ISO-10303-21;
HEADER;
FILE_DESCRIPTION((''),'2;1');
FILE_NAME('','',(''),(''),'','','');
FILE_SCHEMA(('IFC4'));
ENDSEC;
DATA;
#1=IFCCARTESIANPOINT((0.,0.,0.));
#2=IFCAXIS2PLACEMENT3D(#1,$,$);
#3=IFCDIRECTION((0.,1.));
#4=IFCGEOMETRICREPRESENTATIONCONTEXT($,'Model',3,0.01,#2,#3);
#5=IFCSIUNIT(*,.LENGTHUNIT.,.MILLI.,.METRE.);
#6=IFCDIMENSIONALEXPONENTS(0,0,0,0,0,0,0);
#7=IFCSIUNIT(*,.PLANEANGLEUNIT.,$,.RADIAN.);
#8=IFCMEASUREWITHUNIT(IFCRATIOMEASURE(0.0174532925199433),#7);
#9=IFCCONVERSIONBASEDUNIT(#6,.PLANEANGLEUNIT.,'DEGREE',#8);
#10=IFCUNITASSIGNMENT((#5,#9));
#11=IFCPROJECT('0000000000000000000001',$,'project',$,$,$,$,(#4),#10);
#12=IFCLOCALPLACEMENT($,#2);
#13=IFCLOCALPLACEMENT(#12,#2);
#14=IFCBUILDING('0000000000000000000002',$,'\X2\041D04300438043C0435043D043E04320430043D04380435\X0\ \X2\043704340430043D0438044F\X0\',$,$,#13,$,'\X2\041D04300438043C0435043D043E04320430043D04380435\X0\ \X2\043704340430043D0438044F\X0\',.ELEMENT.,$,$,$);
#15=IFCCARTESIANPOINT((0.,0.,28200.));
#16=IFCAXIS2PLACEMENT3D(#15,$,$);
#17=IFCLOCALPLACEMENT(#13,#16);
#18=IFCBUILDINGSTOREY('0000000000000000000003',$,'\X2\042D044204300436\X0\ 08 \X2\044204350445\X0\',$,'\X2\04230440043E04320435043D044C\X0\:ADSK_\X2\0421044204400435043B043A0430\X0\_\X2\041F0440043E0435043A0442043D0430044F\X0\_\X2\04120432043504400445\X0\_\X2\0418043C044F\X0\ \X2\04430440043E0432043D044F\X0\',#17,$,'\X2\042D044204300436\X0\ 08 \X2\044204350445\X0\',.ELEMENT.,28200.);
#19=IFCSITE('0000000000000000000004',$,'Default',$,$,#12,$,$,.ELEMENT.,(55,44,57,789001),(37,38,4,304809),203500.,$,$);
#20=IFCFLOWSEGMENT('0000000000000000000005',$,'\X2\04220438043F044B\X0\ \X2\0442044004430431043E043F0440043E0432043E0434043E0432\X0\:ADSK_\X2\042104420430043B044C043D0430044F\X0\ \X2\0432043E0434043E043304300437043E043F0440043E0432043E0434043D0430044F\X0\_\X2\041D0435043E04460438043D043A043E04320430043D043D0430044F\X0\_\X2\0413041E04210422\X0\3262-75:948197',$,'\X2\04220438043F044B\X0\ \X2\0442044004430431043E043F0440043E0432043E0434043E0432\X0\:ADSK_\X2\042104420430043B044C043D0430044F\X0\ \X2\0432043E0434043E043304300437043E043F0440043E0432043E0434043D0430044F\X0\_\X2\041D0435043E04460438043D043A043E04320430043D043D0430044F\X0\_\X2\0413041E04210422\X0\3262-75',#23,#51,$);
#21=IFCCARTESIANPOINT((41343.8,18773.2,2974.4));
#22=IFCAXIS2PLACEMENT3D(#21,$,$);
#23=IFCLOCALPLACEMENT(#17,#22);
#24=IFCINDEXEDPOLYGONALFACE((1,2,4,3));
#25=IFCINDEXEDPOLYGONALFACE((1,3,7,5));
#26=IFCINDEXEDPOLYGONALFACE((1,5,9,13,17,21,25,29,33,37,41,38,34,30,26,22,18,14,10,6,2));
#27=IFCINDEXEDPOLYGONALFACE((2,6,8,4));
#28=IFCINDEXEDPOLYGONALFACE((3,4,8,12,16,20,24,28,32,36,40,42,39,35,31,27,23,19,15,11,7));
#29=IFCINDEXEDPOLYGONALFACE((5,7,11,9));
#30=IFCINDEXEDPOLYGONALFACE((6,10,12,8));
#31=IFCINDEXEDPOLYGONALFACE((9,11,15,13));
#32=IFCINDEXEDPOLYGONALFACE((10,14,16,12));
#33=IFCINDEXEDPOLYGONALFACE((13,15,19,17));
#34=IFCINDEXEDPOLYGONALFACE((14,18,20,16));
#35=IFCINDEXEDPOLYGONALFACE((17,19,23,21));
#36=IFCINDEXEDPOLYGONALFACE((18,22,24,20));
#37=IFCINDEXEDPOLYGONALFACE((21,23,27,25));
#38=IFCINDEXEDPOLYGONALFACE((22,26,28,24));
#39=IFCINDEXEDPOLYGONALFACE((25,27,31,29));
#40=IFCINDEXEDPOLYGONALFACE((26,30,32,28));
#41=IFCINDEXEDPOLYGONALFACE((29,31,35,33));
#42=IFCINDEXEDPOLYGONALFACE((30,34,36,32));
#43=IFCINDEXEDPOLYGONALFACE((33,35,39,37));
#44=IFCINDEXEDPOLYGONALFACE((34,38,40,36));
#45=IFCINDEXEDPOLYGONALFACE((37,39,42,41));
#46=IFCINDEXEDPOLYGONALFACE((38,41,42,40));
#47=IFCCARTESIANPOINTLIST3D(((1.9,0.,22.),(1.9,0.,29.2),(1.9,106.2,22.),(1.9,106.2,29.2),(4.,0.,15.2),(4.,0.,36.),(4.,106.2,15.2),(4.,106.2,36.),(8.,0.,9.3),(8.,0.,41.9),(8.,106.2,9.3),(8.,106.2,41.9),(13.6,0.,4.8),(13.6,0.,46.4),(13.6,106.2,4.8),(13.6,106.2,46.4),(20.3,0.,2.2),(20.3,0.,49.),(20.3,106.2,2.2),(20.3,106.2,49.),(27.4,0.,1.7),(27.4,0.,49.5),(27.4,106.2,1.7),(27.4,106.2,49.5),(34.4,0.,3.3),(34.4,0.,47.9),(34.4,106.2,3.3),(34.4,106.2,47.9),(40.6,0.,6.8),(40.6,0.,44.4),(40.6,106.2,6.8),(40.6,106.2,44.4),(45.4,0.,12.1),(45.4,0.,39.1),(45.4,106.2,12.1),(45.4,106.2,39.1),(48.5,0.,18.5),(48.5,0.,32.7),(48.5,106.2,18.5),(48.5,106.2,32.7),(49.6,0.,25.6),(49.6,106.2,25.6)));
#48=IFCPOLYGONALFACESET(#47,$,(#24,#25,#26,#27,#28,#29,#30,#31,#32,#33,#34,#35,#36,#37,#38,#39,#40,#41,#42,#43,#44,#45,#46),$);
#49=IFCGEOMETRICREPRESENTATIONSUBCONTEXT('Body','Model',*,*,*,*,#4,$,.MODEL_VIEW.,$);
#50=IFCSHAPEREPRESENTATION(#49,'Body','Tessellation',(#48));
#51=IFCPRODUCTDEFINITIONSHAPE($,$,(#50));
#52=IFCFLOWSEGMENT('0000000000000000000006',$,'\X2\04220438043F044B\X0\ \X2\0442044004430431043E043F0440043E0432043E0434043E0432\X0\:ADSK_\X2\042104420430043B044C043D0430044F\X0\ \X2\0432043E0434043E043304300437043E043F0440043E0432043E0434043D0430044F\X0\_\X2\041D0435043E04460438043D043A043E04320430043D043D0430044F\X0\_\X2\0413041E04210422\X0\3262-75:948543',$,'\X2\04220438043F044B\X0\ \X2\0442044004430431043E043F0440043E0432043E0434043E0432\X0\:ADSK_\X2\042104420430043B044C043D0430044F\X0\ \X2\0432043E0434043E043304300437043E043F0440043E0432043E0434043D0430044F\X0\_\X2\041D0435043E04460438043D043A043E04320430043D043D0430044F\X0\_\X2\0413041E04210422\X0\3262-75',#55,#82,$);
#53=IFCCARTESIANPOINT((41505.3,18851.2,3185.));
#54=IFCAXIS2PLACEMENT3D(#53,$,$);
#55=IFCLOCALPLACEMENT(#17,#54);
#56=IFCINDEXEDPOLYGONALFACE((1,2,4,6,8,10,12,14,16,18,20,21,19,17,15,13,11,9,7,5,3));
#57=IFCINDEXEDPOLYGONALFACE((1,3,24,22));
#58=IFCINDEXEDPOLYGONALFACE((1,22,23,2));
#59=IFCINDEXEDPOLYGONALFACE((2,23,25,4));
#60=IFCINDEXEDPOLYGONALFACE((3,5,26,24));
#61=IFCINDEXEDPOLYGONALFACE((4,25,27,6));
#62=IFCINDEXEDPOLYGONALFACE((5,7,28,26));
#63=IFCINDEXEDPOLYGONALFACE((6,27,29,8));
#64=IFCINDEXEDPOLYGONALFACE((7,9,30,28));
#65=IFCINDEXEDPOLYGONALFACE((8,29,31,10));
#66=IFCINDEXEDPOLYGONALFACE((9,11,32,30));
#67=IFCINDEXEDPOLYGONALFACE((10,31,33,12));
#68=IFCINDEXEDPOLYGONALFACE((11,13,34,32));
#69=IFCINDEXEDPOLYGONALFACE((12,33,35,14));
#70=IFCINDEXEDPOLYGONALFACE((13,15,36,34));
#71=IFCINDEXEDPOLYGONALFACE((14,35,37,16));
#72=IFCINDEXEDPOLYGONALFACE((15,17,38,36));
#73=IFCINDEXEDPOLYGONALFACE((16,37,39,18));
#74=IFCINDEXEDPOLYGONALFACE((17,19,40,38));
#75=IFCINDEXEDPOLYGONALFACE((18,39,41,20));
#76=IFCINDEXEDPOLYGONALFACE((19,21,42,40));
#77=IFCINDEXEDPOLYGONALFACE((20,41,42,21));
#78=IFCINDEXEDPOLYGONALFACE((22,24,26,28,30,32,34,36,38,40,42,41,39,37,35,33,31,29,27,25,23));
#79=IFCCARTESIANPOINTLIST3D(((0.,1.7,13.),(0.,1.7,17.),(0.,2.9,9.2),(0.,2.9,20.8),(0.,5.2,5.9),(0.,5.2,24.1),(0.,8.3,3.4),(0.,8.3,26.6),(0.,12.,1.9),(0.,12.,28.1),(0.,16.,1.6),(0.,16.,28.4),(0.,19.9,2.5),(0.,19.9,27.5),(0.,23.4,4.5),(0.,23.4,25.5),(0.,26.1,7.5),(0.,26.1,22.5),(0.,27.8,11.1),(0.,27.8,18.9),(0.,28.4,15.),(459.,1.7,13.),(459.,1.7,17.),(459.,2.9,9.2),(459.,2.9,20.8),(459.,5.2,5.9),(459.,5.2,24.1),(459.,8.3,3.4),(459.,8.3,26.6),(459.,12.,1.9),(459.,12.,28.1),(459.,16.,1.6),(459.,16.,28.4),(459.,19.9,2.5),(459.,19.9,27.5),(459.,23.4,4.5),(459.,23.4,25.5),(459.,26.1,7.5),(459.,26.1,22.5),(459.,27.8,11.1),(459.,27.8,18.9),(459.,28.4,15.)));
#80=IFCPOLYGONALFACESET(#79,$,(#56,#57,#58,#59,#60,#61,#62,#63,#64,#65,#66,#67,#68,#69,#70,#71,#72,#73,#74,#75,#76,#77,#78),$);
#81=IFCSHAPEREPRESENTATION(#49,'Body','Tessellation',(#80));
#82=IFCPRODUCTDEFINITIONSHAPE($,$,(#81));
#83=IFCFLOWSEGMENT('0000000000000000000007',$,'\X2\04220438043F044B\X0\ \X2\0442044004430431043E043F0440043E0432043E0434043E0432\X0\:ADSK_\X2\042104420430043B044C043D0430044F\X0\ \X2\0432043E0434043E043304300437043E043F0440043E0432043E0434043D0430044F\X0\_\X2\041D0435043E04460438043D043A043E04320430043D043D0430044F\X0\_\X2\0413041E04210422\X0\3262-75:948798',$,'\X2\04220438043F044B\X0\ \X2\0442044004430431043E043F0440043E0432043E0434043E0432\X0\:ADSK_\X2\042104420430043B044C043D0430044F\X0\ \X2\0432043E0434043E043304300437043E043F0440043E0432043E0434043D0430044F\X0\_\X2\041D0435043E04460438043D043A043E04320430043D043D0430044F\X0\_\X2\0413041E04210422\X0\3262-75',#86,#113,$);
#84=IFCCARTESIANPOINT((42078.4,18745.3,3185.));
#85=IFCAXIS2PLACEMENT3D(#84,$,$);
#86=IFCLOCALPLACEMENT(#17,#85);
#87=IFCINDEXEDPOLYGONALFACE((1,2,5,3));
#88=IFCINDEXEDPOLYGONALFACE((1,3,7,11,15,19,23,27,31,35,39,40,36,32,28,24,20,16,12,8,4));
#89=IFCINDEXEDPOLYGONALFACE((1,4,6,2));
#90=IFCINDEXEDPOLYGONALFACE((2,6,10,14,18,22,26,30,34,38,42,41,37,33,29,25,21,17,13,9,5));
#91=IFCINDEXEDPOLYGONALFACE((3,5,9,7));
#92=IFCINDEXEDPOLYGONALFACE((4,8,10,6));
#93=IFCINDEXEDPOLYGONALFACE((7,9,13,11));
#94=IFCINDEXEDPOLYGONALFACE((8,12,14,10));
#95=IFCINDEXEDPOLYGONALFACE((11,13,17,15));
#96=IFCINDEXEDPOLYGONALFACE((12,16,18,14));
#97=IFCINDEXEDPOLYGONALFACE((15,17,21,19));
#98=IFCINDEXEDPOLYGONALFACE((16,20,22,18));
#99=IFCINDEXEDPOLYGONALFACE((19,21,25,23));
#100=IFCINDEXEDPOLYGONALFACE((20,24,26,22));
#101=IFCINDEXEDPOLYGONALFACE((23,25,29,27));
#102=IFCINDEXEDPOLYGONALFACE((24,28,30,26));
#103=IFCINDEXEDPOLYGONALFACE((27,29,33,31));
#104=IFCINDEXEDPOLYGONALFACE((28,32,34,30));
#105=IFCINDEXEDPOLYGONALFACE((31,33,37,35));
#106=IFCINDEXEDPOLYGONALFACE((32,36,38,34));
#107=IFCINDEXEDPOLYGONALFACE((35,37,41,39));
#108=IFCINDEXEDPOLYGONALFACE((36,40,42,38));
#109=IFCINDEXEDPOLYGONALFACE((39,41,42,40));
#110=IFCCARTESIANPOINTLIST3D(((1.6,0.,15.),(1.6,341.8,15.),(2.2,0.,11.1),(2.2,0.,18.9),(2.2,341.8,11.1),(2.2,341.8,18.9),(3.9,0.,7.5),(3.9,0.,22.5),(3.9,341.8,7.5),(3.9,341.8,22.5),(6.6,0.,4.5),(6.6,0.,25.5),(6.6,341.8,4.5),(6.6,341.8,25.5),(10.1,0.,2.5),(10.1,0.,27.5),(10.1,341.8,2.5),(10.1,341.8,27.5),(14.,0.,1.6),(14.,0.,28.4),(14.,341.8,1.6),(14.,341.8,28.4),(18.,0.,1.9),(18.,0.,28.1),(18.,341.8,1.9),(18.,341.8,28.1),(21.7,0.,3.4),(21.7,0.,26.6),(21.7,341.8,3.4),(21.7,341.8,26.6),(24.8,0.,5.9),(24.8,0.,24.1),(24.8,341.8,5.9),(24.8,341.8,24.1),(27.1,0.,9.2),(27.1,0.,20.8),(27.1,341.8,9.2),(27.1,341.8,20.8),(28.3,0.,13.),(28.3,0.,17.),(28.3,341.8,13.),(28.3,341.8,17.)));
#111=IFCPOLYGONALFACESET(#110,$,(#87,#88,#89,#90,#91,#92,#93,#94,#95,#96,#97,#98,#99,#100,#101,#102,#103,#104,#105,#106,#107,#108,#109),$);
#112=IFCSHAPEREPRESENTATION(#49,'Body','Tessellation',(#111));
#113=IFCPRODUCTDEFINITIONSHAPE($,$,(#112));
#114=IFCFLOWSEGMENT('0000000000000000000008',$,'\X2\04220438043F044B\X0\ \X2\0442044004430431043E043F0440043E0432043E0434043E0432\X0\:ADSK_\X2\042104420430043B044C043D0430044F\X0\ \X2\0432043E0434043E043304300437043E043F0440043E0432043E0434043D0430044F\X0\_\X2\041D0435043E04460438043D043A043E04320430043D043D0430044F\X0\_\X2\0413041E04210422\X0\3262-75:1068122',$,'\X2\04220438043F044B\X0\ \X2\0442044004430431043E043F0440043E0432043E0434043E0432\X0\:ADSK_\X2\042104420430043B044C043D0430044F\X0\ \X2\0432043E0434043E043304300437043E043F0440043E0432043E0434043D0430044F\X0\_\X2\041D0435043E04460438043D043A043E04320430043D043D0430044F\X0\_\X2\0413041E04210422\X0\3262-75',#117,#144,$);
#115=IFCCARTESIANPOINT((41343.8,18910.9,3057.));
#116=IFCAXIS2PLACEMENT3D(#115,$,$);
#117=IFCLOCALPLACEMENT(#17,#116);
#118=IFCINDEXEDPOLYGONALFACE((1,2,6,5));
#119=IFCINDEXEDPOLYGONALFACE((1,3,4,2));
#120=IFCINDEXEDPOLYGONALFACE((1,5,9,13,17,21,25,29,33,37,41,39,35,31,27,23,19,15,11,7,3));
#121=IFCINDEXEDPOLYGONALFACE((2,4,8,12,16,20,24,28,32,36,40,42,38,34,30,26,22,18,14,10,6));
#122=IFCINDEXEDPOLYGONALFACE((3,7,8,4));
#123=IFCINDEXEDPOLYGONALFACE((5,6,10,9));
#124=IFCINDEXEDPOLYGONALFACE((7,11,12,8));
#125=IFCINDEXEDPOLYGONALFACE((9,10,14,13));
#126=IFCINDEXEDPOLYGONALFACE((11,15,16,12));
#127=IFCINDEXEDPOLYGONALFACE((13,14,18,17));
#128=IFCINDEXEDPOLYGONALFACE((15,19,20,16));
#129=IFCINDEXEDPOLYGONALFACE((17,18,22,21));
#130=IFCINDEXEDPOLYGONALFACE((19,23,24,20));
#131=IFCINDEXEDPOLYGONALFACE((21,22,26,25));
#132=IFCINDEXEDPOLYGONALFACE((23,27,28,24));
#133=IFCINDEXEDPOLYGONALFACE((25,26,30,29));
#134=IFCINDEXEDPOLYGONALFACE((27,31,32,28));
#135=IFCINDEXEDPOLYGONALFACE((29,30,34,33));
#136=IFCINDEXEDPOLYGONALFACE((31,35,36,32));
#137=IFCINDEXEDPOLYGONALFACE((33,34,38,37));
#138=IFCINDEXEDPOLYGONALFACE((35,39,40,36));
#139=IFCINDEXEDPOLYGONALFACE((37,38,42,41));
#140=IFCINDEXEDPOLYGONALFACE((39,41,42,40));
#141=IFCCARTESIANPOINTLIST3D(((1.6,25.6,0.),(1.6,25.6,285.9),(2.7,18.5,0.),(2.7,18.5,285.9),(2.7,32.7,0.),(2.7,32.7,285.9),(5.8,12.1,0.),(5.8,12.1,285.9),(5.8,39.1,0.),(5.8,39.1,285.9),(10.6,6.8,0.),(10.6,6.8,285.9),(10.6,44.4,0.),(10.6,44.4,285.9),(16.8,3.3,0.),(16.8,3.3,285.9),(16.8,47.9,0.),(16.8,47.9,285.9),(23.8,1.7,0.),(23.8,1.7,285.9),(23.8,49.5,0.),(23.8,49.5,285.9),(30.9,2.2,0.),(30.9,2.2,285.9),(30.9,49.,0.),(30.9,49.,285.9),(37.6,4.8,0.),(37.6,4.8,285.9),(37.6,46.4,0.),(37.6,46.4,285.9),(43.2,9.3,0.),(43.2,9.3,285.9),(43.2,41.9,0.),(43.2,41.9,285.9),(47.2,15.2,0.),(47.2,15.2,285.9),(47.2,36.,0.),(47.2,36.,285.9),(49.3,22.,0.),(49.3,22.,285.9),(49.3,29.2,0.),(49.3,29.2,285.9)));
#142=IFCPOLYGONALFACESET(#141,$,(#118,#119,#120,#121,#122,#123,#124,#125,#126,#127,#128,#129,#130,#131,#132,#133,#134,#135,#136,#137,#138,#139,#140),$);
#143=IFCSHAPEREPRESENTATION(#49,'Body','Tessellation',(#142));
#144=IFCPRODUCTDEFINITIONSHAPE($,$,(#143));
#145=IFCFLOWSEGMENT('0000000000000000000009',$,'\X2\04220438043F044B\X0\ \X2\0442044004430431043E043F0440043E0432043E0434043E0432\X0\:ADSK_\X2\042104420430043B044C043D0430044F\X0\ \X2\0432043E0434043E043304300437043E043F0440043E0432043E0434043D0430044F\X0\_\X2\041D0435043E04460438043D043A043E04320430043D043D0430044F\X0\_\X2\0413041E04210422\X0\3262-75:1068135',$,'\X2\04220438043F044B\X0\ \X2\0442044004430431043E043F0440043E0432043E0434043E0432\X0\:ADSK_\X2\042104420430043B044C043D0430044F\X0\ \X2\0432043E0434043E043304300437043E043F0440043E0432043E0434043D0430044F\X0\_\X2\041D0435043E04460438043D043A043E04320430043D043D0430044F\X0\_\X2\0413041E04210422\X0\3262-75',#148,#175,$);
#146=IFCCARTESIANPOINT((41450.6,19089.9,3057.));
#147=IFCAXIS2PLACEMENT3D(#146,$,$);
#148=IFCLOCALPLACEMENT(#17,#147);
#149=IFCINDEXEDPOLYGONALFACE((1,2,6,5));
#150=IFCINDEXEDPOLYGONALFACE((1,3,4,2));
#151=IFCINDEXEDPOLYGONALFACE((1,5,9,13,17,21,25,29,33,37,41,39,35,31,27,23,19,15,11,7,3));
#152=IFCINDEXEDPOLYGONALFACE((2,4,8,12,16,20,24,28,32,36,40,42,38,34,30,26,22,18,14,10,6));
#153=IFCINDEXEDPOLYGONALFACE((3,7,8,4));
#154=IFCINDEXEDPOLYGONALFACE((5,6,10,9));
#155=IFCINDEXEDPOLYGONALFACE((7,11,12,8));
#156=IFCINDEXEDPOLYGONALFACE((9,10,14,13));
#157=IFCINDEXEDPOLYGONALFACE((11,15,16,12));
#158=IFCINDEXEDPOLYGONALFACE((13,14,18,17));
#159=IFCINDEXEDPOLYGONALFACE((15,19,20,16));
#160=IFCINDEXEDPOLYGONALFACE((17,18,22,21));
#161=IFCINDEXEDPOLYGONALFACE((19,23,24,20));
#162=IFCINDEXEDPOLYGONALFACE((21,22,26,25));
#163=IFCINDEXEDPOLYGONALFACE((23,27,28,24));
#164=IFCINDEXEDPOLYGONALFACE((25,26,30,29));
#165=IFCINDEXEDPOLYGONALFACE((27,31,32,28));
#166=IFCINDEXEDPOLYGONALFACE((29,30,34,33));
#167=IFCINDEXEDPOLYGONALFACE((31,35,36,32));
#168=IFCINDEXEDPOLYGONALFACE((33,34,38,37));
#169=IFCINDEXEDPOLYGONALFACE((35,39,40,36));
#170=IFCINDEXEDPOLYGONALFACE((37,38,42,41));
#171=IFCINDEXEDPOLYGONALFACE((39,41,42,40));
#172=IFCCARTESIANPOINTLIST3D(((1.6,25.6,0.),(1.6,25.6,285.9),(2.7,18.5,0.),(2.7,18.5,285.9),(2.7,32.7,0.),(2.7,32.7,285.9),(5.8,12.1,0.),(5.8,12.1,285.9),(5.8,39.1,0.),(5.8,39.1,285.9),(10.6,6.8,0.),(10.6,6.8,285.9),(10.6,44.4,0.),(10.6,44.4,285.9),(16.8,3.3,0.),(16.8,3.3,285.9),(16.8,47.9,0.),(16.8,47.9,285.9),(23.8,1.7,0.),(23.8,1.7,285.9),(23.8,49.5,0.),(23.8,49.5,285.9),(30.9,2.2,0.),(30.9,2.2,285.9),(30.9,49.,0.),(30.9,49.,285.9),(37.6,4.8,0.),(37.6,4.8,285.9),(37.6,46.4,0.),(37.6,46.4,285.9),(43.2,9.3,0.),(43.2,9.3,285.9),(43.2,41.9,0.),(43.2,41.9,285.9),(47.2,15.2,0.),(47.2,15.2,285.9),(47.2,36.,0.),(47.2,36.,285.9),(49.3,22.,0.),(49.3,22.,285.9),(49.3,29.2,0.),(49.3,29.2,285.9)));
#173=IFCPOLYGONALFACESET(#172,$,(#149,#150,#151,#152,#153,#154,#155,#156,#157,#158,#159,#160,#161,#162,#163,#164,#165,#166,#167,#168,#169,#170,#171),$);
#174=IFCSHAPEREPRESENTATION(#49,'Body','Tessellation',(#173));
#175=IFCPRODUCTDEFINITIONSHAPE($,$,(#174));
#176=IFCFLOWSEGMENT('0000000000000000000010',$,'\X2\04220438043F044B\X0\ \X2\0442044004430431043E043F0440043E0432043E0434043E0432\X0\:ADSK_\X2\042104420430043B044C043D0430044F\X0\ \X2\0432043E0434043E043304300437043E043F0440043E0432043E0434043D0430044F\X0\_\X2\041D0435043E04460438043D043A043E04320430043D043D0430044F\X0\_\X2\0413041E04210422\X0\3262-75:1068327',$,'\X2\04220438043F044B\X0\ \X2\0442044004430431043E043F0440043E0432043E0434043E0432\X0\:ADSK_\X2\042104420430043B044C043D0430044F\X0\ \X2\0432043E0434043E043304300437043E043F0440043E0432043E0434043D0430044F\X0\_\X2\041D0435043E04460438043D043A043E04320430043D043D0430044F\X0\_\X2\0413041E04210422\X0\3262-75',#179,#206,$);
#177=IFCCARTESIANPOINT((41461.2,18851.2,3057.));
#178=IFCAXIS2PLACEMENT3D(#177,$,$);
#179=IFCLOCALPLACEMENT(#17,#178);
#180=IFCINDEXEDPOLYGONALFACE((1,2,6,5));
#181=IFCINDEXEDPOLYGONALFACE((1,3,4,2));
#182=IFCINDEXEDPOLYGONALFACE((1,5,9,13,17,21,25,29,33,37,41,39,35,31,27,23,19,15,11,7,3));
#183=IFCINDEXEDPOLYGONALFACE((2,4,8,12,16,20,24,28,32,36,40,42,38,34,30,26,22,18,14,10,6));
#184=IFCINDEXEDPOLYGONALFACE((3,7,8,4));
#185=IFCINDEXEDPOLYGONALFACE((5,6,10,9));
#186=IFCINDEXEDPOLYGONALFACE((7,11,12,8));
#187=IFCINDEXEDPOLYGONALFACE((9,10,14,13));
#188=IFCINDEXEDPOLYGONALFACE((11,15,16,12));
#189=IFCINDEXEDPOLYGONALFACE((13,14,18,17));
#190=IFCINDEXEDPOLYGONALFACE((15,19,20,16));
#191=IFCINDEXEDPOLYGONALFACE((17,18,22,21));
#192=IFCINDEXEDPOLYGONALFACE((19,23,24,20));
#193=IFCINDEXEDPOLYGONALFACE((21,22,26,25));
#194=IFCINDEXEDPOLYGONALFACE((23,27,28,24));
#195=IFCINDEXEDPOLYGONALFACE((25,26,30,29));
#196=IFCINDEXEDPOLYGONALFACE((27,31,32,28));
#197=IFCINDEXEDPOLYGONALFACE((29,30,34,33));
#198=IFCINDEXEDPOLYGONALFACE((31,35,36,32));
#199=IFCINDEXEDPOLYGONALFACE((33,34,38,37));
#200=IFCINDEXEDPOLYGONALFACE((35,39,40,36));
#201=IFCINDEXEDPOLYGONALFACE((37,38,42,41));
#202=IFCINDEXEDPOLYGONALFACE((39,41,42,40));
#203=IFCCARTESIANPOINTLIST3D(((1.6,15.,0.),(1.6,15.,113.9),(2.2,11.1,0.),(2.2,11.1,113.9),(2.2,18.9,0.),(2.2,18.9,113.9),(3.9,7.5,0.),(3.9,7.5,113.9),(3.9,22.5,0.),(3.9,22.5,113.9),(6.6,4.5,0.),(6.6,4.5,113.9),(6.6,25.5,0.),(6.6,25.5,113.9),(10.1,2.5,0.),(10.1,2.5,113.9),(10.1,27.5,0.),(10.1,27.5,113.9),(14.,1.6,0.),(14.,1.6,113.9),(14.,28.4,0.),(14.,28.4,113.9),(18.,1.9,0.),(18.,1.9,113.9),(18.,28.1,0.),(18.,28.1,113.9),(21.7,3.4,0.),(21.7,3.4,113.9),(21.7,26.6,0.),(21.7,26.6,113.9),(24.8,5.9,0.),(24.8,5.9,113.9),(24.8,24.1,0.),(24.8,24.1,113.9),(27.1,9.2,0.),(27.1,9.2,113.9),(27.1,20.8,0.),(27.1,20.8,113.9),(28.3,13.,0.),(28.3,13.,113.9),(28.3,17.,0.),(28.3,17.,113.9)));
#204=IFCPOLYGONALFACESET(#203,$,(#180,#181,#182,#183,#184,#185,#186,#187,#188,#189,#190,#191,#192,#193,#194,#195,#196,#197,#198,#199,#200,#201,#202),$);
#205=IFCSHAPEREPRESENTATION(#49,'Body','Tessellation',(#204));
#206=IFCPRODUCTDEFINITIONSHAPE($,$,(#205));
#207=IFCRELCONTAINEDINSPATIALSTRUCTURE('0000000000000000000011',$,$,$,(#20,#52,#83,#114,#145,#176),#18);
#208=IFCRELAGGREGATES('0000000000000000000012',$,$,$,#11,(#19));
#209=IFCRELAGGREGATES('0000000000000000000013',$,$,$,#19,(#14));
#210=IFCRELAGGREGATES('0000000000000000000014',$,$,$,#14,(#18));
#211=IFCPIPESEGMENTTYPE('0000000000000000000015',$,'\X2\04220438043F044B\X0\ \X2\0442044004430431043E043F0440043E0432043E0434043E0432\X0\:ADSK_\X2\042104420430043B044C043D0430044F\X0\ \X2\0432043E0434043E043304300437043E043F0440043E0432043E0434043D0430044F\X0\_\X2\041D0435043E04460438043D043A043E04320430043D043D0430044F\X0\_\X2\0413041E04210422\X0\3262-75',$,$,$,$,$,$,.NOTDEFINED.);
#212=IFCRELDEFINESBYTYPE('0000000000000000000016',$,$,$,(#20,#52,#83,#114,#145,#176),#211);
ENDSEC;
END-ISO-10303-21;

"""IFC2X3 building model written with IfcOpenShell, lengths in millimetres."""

from ifc_helpers import new_model, entity, si_unit, converted_unit, direction, frame, origin, origin_2d_with_axis, place, context, subcontext, project, spatial, circle, extrude, type_object, element, save


model = new_model("IFC2X3")

# Units and contexts
model_context = context("Model", 3, precision=0.01, world=origin(), true_north=direction((0.0, 1.0)))
body_context = subcontext(model_context, "Body", "Model", "MODEL_VIEW")
ifc_project = project(units=[si_unit("LENGTHUNIT", "METRE", prefix="MILLI"), converted_unit("PLANEANGLEUNIT", "DEGREE", entity("IfcRatioMeasure", 0.0174532925199433), si_unit("PLANEANGLEUNIT", "RADIAN"), dimensions=[0, 0, 0, 0, 0, 0, 0])], contexts=[model_context])

# Site, building, storey
site_placement = place(None, origin())
site = spatial("IfcSite", under=ifc_project, at=site_placement, Name="Default", CompositionType="ELEMENT", RefLatitude=(55, 44, 57, 789001), RefLongitude=(37, 38, 4, 304809), RefElevation=203500.0)
building_placement = place(site_placement, origin())
building = spatial("IfcBuilding", under=site, at=building_placement, Name="Наименование здания", LongName="Наименование здания", CompositionType="ELEMENT")
storey_placement = place(building_placement, frame((0.0, 0.0, 28200.0)))
storey = spatial("IfcBuildingStorey", under=building, at=storey_placement, Name="Этаж 08 тех", ObjectType="Уровень:ADSK_Стрелка_Проектная_Вверх_Имя уровня", LongName="Этаж 08 тех", CompositionType="ELEMENT", Elevation=28200.0)

# Flow segments
pipe_segment_type = type_object("IfcPipeSegmentType", Name="Типы трубопроводов:ADSK_Стальная водогазопроводная_Неоцинкованная_ГОСТ3262-75", PredefinedType="NOTDEFINED")
flow_segment_1_placement = place(storey_placement, frame((41343.8, 18773.2, 2974.4)))
element("IfcFlowSegment", 1, at=flow_segment_1_placement, inside=storey, type_object=pipe_segment_type, Name="Типы трубопроводов:ADSK_Стальная водогазопроводная_Неоцинкованная_ГОСТ3262-75:948197", ObjectType="Типы трубопроводов:ADSK_Стальная водогазопроводная_Неоцинкованная_ГОСТ3262-75", context=body_context, shape_type="SweptSolid", body=[
    extrude(circle(Radius=24.0, at=origin_2d_with_axis()), frame((25.6, 0.0, 25.6), z_axis=(0.0, 1.0, 0.0), x_axis=(1.0, 0.0, 0.0)), (0.0, 0.0, 1.0), 106.2),
])
flow_segment_2_placement = place(storey_placement, frame((41505.3, 18851.2, 3185.0)))
element("IfcFlowSegment", 2, at=flow_segment_2_placement, inside=storey, type_object=pipe_segment_type, Name="Типы трубопроводов:ADSK_Стальная водогазопроводная_Неоцинкованная_ГОСТ3262-75:948543", ObjectType="Типы трубопроводов:ADSK_Стальная водогазопроводная_Неоцинкованная_ГОСТ3262-75", context=body_context, shape_type="SweptSolid", body=[
    extrude(circle(Radius=13.4, at=origin_2d_with_axis()), frame((0.0, 15.0, 15.0), z_axis=(1.0, 0.0, 0.0), x_axis=(0.0, 1.0, 0.0)), (0.0, 0.0, 1.0), 459.0),
])
flow_segment_3_placement = place(storey_placement, frame((42078.4, 18745.3, 3185.0)))
element("IfcFlowSegment", 3, at=flow_segment_3_placement, inside=storey, type_object=pipe_segment_type, Name="Типы трубопроводов:ADSK_Стальная водогазопроводная_Неоцинкованная_ГОСТ3262-75:948798", ObjectType="Типы трубопроводов:ADSK_Стальная водогазопроводная_Неоцинкованная_ГОСТ3262-75", context=body_context, shape_type="SweptSolid", body=[
    extrude(circle(Radius=13.4, at=origin_2d_with_axis()), frame((15.0, 0.0, 15.0), z_axis=(0.0, 1.0, 0.0), x_axis=(-1.0, 0.0, 0.0)), (0.0, 0.0, 1.0), 341.8),
])
for number, where, name in (
    (4, (41343.8, 18910.9, 3057.0), "Типы трубопроводов:ADSK_Стальная водогазопроводная_Неоцинкованная_ГОСТ3262-75:1068122"),
    (5, (41450.6, 19089.9, 3057.0), "Типы трубопроводов:ADSK_Стальная водогазопроводная_Неоцинкованная_ГОСТ3262-75:1068135"),
):
    element("IfcFlowSegment", number, at=place(storey_placement, frame(where)), inside=storey, type_object=pipe_segment_type, Name=name, ObjectType="Типы трубопроводов:ADSK_Стальная водогазопроводная_Неоцинкованная_ГОСТ3262-75", context=body_context, shape_type="SweptSolid", body=[
        extrude(circle(Radius=24.0, at=origin_2d_with_axis()), frame((25.6, 25.6, 0.0), z_axis=(0.0, 0.0, 1.0), x_axis=(-1.0, 0.0, 0.0)), (0.0, 0.0, 1.0), 285.9),
    ])
flow_segment_4_placement = place(storey_placement, frame((41461.2, 18851.2, 3057.0)))
element("IfcFlowSegment", 6, at=flow_segment_4_placement, inside=storey, type_object=pipe_segment_type, Name="Типы трубопроводов:ADSK_Стальная водогазопроводная_Неоцинкованная_ГОСТ3262-75:1068327", ObjectType="Типы трубопроводов:ADSK_Стальная водогазопроводная_Неоцинкованная_ГОСТ3262-75", context=body_context, shape_type="SweptSolid", body=[
    extrude(circle(Radius=13.4, at=origin_2d_with_axis()), frame((15.0, 15.0, 0.0), z_axis=(0.0, 0.0, 1.0), x_axis=(-1.0, 0.0, 0.0)), (0.0, 0.0, 1.0), 113.9),
])

save(model, "model.ifc")
